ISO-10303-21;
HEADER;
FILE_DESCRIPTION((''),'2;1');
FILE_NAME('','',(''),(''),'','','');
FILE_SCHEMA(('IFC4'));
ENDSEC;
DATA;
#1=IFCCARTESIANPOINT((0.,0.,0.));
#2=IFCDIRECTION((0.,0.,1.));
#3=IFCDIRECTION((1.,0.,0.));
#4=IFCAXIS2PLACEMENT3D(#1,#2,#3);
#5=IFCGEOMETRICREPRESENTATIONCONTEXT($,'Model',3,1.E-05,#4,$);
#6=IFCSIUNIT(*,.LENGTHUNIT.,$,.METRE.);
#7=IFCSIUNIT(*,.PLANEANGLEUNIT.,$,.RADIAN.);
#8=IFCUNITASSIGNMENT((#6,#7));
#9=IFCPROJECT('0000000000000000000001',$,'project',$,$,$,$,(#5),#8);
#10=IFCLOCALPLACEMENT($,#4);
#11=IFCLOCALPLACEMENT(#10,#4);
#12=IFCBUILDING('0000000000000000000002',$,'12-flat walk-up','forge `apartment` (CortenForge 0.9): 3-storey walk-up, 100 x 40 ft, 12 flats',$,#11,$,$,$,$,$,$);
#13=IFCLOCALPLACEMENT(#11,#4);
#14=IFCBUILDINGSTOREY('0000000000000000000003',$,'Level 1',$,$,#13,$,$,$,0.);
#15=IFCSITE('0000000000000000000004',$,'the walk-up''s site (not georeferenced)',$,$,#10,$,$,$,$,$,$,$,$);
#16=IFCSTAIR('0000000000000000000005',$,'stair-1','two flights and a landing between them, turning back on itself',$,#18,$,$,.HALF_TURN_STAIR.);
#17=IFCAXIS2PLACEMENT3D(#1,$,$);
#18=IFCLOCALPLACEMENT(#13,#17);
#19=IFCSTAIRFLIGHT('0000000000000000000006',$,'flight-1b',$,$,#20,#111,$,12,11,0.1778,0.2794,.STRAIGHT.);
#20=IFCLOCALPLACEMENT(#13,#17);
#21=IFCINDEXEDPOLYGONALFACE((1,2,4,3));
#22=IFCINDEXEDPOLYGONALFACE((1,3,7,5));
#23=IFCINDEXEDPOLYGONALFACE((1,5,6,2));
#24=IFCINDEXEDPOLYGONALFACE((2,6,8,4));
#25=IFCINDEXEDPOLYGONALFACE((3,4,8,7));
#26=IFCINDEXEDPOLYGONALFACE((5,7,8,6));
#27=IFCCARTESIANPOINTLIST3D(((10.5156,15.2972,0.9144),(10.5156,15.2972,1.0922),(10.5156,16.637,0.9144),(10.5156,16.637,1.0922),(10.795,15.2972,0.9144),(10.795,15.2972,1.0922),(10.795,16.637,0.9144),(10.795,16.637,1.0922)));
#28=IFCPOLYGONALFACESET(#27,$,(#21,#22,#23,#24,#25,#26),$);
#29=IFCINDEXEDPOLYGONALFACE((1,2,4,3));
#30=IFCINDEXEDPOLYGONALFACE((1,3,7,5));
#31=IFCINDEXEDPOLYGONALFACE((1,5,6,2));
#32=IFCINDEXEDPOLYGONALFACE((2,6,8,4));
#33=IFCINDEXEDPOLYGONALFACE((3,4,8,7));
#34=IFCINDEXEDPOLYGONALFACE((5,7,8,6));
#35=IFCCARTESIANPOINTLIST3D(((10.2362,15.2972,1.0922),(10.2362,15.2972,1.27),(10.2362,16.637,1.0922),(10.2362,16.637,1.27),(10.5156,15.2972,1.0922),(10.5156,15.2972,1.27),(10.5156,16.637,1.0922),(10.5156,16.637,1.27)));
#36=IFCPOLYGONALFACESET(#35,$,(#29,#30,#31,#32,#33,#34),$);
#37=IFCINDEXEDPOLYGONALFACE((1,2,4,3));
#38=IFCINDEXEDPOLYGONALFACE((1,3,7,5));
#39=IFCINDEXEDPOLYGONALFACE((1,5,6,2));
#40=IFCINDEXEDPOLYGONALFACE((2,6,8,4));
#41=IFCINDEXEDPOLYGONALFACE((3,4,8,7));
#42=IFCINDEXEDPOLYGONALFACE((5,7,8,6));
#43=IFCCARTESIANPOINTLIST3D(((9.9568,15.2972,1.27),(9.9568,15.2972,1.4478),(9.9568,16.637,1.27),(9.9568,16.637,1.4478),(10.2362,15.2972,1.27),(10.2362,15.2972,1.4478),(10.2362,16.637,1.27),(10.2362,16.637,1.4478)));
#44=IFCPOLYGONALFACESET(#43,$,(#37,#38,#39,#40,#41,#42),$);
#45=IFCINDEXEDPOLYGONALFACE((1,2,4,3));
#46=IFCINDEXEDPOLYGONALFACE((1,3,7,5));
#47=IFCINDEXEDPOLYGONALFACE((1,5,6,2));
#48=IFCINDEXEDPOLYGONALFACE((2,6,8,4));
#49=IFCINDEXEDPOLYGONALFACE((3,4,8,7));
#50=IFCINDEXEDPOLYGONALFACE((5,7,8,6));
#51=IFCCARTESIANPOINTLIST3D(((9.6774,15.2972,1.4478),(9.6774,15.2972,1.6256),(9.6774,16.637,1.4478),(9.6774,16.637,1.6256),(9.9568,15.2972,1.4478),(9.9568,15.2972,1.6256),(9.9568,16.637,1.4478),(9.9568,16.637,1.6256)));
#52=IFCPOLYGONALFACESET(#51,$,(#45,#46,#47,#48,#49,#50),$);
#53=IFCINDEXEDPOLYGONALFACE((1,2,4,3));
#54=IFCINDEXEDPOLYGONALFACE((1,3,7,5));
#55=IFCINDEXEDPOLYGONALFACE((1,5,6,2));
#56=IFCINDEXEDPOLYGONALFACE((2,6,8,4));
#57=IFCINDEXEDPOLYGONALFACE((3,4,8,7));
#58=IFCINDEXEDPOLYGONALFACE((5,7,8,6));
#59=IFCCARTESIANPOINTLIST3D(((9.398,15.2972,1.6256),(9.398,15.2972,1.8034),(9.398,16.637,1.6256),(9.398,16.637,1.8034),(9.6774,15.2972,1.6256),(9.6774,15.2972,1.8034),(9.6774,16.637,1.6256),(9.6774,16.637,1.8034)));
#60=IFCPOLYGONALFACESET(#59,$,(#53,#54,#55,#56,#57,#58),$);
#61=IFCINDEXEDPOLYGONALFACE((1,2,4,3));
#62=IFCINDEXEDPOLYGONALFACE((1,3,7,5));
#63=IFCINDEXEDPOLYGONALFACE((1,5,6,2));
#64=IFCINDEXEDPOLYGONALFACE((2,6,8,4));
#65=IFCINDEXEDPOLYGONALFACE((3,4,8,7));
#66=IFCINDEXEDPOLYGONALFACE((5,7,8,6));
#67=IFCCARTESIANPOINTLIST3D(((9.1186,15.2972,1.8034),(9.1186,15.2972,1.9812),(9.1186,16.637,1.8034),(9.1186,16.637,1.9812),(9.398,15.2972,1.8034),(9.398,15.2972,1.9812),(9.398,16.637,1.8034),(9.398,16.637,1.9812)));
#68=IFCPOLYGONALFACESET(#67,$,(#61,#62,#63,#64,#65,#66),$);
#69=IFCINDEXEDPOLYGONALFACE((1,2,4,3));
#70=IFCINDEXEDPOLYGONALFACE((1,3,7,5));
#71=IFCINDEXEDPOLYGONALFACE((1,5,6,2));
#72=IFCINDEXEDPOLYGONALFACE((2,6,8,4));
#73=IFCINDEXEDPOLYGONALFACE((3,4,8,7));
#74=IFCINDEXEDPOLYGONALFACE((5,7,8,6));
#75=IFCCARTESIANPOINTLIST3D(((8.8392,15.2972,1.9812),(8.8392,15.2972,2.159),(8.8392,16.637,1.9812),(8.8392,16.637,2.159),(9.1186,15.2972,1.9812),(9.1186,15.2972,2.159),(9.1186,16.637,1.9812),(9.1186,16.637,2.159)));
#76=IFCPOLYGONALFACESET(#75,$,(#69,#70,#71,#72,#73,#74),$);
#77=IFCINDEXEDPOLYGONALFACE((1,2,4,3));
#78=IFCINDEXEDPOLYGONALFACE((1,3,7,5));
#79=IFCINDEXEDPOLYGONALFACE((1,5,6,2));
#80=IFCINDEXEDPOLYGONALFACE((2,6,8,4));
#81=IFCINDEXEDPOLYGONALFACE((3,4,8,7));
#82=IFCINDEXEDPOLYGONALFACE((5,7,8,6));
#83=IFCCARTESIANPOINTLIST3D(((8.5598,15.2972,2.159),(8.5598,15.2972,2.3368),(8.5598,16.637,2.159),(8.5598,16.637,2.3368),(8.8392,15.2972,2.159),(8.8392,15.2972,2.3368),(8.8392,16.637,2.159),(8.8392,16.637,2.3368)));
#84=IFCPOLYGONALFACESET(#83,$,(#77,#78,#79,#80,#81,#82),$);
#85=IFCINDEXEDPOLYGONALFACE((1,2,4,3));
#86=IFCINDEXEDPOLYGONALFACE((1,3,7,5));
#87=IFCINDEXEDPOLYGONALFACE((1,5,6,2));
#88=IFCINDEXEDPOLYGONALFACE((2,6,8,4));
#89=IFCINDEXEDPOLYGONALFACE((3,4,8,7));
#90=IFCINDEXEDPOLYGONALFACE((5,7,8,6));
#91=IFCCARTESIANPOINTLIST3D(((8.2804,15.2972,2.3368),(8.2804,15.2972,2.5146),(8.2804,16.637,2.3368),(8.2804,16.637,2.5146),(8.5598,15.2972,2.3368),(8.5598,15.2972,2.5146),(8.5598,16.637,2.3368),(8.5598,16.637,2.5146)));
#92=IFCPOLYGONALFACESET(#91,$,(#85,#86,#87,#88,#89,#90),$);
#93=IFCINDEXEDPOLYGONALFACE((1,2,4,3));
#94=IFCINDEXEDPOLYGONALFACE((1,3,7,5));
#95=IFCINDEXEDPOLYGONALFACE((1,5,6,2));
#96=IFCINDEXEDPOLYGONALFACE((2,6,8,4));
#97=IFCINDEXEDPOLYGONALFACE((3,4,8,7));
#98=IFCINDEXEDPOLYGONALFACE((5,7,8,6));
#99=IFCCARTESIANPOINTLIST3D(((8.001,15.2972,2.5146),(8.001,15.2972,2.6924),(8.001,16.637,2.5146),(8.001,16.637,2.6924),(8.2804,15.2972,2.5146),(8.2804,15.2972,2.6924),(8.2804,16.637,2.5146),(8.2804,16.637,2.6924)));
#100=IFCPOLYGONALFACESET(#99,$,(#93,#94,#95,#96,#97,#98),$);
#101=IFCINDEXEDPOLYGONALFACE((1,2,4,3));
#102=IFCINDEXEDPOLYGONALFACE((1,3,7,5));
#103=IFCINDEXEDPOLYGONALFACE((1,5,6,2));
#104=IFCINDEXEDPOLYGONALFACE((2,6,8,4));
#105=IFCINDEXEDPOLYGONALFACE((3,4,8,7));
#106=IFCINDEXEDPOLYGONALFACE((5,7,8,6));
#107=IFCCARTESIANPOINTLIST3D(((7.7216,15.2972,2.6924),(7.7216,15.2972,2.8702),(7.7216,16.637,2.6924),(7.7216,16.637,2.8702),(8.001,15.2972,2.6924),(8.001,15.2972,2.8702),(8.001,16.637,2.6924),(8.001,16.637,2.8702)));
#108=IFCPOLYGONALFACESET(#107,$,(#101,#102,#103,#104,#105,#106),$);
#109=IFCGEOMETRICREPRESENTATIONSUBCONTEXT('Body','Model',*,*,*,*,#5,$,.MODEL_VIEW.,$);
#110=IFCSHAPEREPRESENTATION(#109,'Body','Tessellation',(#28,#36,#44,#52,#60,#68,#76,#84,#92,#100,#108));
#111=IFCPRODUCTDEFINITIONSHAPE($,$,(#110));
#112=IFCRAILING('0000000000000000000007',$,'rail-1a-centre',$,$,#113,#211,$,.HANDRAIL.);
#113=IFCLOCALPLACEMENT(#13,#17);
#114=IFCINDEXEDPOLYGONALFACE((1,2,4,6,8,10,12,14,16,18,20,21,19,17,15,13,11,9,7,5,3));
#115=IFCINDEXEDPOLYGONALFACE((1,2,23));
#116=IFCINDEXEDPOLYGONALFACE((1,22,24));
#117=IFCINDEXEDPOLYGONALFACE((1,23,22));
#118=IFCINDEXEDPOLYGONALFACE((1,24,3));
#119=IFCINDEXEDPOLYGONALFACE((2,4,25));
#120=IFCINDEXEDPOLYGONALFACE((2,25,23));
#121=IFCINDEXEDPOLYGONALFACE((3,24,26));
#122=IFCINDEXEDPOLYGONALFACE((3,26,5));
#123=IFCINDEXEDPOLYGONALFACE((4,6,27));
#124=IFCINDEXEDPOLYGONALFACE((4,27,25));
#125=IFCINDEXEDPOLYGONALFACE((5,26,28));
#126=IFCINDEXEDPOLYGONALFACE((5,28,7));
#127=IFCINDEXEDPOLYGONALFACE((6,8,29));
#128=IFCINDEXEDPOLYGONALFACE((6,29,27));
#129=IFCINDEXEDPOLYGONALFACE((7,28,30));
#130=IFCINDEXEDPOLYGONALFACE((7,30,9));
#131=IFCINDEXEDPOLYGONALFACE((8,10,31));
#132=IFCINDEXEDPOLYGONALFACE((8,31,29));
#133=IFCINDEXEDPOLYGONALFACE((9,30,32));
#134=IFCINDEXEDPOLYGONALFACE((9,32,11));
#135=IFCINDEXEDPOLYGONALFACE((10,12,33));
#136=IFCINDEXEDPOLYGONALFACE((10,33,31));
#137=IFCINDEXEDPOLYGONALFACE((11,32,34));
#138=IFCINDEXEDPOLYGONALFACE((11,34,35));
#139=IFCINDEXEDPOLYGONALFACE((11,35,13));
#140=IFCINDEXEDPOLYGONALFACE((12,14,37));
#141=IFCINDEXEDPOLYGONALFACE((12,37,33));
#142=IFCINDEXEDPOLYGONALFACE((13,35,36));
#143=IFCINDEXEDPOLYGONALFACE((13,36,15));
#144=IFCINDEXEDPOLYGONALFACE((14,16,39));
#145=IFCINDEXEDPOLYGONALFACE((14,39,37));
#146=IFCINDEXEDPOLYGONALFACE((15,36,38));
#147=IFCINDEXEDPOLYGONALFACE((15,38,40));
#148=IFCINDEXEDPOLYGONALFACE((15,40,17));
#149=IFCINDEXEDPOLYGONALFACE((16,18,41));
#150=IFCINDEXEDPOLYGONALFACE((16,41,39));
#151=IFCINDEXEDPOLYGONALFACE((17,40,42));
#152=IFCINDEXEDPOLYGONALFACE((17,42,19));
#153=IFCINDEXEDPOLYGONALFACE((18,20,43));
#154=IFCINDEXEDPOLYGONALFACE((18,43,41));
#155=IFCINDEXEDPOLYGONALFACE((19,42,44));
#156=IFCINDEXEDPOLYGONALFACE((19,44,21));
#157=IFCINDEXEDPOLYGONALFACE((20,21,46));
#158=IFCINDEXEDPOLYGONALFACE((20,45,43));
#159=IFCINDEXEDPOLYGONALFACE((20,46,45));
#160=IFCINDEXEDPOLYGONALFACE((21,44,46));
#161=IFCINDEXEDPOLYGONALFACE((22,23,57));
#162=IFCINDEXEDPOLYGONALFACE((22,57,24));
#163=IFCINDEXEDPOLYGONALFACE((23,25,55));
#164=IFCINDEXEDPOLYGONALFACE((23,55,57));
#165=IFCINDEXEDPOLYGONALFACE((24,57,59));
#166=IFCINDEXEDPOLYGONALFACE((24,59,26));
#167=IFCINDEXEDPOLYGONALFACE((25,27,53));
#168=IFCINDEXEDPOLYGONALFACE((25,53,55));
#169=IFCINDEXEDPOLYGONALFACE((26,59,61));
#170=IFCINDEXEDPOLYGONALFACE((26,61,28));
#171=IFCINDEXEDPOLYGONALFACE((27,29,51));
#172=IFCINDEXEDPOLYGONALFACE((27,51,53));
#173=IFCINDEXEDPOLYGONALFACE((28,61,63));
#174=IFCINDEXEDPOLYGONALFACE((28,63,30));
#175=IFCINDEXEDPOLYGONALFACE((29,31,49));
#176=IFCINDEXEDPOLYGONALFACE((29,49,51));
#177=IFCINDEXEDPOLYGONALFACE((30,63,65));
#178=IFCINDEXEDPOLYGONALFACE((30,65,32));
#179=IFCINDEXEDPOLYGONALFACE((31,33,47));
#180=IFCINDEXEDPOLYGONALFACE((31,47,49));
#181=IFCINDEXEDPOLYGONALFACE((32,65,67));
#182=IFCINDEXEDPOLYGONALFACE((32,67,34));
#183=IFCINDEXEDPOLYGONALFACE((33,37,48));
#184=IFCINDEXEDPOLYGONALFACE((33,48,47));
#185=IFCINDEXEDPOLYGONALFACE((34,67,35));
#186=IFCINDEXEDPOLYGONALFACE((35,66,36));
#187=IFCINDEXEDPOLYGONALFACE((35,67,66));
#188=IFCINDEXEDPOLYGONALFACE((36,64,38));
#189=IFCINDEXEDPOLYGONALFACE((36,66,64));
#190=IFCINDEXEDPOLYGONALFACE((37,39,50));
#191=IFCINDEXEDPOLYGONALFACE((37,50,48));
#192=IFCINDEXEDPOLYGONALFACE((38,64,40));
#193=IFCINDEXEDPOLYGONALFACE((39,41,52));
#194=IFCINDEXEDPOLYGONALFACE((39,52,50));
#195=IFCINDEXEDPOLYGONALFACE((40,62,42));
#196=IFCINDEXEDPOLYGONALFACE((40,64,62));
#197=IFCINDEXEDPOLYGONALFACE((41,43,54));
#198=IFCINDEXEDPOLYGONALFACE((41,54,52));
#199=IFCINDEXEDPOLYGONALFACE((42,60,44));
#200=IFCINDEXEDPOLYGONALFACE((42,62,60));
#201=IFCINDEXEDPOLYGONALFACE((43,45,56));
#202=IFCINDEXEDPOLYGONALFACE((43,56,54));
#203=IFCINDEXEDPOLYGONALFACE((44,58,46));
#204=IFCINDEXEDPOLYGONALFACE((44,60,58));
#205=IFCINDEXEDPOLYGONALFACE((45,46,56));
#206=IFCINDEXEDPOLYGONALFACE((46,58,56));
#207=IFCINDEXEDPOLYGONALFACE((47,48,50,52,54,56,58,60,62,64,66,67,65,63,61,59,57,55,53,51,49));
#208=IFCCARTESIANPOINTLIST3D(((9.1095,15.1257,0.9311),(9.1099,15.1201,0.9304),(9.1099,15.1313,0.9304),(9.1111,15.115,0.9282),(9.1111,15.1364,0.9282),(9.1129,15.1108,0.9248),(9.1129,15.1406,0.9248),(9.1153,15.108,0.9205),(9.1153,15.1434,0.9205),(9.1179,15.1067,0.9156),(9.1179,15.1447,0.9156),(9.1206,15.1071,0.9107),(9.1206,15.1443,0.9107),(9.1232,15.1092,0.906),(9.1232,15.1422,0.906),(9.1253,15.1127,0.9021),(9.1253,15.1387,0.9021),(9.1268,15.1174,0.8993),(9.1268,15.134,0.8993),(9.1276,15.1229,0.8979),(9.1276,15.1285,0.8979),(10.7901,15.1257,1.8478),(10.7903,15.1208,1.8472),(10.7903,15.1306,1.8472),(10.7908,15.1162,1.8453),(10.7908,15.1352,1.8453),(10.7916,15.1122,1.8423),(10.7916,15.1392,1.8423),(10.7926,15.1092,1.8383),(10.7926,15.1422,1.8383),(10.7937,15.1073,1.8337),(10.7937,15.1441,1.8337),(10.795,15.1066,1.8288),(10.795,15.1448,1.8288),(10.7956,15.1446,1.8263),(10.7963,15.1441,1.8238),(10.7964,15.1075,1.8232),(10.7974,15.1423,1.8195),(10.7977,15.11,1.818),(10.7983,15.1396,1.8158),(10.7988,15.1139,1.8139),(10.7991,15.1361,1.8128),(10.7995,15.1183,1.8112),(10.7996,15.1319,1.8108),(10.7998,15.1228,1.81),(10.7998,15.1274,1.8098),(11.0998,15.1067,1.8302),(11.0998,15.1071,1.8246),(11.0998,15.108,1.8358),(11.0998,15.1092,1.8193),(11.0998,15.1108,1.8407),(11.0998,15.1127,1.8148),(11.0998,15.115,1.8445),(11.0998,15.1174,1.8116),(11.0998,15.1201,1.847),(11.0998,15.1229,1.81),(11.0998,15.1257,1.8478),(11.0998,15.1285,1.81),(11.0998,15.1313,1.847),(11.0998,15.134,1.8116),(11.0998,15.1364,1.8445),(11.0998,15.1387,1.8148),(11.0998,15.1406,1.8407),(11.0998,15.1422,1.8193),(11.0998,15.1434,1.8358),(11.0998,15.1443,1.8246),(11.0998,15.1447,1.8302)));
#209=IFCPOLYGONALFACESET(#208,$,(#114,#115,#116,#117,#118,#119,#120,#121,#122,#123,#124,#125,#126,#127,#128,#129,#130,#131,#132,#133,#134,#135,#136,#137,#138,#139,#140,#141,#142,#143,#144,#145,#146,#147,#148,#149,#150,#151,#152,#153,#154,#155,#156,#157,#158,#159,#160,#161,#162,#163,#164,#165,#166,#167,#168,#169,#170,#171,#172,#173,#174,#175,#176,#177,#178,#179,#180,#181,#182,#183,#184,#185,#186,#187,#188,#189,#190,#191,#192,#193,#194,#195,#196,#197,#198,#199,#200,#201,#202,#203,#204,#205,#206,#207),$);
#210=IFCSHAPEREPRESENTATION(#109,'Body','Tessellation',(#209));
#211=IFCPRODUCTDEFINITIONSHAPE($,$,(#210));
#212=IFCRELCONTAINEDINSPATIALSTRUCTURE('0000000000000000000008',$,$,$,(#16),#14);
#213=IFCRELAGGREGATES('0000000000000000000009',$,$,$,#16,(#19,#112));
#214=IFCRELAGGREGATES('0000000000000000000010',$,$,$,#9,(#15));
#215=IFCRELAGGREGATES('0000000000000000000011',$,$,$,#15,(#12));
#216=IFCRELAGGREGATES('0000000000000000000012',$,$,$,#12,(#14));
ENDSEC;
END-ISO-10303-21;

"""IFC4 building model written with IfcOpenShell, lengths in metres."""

from ifc_helpers import new_model, entity, si_unit, frame, frame_2d, origin_with_axes, place, context, subcontext, project, spatial, rectangle, extrude, element, aggregate, save


model = new_model("IFC4")

# Units and contexts
model_context = context("Model", 3, precision=1e-05, world=origin_with_axes())
body_context = subcontext(model_context, "Body", "Model", "MODEL_VIEW")
ifc_project = project(units=[si_unit("LENGTHUNIT", "METRE"), si_unit("PLANEANGLEUNIT", "RADIAN")], contexts=[model_context])

# Site, building, storey
site_placement = place(None, origin_with_axes())
site = spatial("IfcSite", under=ifc_project, at=site_placement, Name="the walk-up's site (not georeferenced)")
building_placement = place(site_placement, origin_with_axes())
building = spatial("IfcBuilding", under=site, at=building_placement, Name="12-flat walk-up", Description="forge `apartment` (CortenForge 0.9): 3-storey walk-up, 100 x 40 ft, 12 flats")
storey_placement = place(building_placement, origin_with_axes())
storey = spatial("IfcBuildingStorey", under=building, at=storey_placement, Name="Level 1", Elevation=0.0)

# Stair, stair flight, railing
stair_placement = place(storey_placement, origin_with_axes())
stair = element("IfcStair", 1, at=stair_placement, inside=storey, Name="stair-1", Description="two flights and a landing between them, turning back on itself", PredefinedType="HALF_TURN_STAIR")
stair_flight_placement = place(stair_placement, frame((7.7216, 15.2972, 0.9144), z_axis=(0.0, 0.0, 1.0), x_axis=(1.0, 0.0, 0.0)))
stair_flight = element("IfcStairFlight", 2, at=stair_flight_placement, Name="flight-1b", NumberOfRisers=12, NumberOfTreads=11, PredefinedType="STRAIGHT", RiserHeight=0.1778, TreadLength=0.2794, context=body_context, shape_type="SweptSolid", body=[
    extrude(rectangle(XDim=0.2794, YDim=1.3399, at=frame_2d((0.1397, 0.6699))), frame((2.794, 0.0, 0.0)), (0.0, 0.0, 1.0), 0.1778),
    extrude(rectangle(XDim=0.2794, YDim=1.3399, at=frame_2d((0.1397, 0.6699))), frame((2.5146, 0.0, 0.1778)), (0.0, 0.0, 1.0), 0.1778),
    extrude(rectangle(XDim=0.2794, YDim=1.3399, at=frame_2d((0.1397, 0.6699))), frame((2.2352, 0.0, 0.3556)), (0.0, 0.0, 1.0), 0.1778),
    extrude(rectangle(XDim=0.2794, YDim=1.3399, at=frame_2d((0.1397, 0.6699))), frame((1.9558, 0.0, 0.5334)), (0.0, 0.0, 1.0), 0.1778),
    extrude(rectangle(XDim=0.2794, YDim=1.3399, at=frame_2d((0.1397, 0.6699))), frame((1.6764, 0.0, 0.7112)), (0.0, 0.0, 1.0), 0.1778),
    extrude(rectangle(XDim=0.2794, YDim=1.3399, at=frame_2d((0.1397, 0.6699))), frame((1.397, 0.0, 0.889)), (0.0, 0.0, 1.0), 0.1778),
    extrude(rectangle(XDim=0.2794, YDim=1.3399, at=frame_2d((0.1397, 0.6699))), frame((1.1176, 0.0, 1.0668)), (0.0, 0.0, 1.0), 0.1778),
    extrude(rectangle(XDim=0.2794, YDim=1.3399, at=frame_2d((0.1397, 0.6699))), frame((0.8382, 0.0, 1.2446)), (0.0, 0.0, 1.0), 0.1778),
    extrude(rectangle(XDim=0.2794, YDim=1.3399, at=frame_2d((0.1397, 0.6699))), frame((0.5588, 0.0, 1.4224)), (0.0, 0.0, 1.0), 0.1778),
    extrude(rectangle(XDim=0.2794, YDim=1.3399, at=frame_2d((0.1397, 0.6699))), frame((0.2794, 0.0, 1.6002)), (0.0, 0.0, 1.0), 0.1778),
    extrude(rectangle(XDim=0.2794, YDim=1.3399, at=frame_2d((0.1397, 0.6699))), frame((0.0, 0.0, 1.778)), (0.0, 0.0, 1.0), 0.1778),
])
railing_1_placement = place(stair_placement, frame((9.1186, 15.1257, 0.9144), z_axis=(0.0, 0.0, 1.0), x_axis=(1.0, 0.0, 0.0)))
railing_1 = element("IfcRailing", 3, at=railing_1_placement, Name="rail-1a-centre", PredefinedType="HANDRAIL", context=body_context, shape_type="AdvancedSweptSolid", body=[
    entity("IfcSweptDiskSolid", entity("IfcPolyline", [entity("IfcCartesianPoint", [0.0, 0.0, 0.0]), entity("IfcCartesianPoint", [1.6764, 0.0, 0.9144]), entity("IfcCartesianPoint", [1.9812, 0.0, 0.9144])]), 0.0191),
])
aggregate(stair, [stair_flight, railing_1])

save(model, "model.ifc")
